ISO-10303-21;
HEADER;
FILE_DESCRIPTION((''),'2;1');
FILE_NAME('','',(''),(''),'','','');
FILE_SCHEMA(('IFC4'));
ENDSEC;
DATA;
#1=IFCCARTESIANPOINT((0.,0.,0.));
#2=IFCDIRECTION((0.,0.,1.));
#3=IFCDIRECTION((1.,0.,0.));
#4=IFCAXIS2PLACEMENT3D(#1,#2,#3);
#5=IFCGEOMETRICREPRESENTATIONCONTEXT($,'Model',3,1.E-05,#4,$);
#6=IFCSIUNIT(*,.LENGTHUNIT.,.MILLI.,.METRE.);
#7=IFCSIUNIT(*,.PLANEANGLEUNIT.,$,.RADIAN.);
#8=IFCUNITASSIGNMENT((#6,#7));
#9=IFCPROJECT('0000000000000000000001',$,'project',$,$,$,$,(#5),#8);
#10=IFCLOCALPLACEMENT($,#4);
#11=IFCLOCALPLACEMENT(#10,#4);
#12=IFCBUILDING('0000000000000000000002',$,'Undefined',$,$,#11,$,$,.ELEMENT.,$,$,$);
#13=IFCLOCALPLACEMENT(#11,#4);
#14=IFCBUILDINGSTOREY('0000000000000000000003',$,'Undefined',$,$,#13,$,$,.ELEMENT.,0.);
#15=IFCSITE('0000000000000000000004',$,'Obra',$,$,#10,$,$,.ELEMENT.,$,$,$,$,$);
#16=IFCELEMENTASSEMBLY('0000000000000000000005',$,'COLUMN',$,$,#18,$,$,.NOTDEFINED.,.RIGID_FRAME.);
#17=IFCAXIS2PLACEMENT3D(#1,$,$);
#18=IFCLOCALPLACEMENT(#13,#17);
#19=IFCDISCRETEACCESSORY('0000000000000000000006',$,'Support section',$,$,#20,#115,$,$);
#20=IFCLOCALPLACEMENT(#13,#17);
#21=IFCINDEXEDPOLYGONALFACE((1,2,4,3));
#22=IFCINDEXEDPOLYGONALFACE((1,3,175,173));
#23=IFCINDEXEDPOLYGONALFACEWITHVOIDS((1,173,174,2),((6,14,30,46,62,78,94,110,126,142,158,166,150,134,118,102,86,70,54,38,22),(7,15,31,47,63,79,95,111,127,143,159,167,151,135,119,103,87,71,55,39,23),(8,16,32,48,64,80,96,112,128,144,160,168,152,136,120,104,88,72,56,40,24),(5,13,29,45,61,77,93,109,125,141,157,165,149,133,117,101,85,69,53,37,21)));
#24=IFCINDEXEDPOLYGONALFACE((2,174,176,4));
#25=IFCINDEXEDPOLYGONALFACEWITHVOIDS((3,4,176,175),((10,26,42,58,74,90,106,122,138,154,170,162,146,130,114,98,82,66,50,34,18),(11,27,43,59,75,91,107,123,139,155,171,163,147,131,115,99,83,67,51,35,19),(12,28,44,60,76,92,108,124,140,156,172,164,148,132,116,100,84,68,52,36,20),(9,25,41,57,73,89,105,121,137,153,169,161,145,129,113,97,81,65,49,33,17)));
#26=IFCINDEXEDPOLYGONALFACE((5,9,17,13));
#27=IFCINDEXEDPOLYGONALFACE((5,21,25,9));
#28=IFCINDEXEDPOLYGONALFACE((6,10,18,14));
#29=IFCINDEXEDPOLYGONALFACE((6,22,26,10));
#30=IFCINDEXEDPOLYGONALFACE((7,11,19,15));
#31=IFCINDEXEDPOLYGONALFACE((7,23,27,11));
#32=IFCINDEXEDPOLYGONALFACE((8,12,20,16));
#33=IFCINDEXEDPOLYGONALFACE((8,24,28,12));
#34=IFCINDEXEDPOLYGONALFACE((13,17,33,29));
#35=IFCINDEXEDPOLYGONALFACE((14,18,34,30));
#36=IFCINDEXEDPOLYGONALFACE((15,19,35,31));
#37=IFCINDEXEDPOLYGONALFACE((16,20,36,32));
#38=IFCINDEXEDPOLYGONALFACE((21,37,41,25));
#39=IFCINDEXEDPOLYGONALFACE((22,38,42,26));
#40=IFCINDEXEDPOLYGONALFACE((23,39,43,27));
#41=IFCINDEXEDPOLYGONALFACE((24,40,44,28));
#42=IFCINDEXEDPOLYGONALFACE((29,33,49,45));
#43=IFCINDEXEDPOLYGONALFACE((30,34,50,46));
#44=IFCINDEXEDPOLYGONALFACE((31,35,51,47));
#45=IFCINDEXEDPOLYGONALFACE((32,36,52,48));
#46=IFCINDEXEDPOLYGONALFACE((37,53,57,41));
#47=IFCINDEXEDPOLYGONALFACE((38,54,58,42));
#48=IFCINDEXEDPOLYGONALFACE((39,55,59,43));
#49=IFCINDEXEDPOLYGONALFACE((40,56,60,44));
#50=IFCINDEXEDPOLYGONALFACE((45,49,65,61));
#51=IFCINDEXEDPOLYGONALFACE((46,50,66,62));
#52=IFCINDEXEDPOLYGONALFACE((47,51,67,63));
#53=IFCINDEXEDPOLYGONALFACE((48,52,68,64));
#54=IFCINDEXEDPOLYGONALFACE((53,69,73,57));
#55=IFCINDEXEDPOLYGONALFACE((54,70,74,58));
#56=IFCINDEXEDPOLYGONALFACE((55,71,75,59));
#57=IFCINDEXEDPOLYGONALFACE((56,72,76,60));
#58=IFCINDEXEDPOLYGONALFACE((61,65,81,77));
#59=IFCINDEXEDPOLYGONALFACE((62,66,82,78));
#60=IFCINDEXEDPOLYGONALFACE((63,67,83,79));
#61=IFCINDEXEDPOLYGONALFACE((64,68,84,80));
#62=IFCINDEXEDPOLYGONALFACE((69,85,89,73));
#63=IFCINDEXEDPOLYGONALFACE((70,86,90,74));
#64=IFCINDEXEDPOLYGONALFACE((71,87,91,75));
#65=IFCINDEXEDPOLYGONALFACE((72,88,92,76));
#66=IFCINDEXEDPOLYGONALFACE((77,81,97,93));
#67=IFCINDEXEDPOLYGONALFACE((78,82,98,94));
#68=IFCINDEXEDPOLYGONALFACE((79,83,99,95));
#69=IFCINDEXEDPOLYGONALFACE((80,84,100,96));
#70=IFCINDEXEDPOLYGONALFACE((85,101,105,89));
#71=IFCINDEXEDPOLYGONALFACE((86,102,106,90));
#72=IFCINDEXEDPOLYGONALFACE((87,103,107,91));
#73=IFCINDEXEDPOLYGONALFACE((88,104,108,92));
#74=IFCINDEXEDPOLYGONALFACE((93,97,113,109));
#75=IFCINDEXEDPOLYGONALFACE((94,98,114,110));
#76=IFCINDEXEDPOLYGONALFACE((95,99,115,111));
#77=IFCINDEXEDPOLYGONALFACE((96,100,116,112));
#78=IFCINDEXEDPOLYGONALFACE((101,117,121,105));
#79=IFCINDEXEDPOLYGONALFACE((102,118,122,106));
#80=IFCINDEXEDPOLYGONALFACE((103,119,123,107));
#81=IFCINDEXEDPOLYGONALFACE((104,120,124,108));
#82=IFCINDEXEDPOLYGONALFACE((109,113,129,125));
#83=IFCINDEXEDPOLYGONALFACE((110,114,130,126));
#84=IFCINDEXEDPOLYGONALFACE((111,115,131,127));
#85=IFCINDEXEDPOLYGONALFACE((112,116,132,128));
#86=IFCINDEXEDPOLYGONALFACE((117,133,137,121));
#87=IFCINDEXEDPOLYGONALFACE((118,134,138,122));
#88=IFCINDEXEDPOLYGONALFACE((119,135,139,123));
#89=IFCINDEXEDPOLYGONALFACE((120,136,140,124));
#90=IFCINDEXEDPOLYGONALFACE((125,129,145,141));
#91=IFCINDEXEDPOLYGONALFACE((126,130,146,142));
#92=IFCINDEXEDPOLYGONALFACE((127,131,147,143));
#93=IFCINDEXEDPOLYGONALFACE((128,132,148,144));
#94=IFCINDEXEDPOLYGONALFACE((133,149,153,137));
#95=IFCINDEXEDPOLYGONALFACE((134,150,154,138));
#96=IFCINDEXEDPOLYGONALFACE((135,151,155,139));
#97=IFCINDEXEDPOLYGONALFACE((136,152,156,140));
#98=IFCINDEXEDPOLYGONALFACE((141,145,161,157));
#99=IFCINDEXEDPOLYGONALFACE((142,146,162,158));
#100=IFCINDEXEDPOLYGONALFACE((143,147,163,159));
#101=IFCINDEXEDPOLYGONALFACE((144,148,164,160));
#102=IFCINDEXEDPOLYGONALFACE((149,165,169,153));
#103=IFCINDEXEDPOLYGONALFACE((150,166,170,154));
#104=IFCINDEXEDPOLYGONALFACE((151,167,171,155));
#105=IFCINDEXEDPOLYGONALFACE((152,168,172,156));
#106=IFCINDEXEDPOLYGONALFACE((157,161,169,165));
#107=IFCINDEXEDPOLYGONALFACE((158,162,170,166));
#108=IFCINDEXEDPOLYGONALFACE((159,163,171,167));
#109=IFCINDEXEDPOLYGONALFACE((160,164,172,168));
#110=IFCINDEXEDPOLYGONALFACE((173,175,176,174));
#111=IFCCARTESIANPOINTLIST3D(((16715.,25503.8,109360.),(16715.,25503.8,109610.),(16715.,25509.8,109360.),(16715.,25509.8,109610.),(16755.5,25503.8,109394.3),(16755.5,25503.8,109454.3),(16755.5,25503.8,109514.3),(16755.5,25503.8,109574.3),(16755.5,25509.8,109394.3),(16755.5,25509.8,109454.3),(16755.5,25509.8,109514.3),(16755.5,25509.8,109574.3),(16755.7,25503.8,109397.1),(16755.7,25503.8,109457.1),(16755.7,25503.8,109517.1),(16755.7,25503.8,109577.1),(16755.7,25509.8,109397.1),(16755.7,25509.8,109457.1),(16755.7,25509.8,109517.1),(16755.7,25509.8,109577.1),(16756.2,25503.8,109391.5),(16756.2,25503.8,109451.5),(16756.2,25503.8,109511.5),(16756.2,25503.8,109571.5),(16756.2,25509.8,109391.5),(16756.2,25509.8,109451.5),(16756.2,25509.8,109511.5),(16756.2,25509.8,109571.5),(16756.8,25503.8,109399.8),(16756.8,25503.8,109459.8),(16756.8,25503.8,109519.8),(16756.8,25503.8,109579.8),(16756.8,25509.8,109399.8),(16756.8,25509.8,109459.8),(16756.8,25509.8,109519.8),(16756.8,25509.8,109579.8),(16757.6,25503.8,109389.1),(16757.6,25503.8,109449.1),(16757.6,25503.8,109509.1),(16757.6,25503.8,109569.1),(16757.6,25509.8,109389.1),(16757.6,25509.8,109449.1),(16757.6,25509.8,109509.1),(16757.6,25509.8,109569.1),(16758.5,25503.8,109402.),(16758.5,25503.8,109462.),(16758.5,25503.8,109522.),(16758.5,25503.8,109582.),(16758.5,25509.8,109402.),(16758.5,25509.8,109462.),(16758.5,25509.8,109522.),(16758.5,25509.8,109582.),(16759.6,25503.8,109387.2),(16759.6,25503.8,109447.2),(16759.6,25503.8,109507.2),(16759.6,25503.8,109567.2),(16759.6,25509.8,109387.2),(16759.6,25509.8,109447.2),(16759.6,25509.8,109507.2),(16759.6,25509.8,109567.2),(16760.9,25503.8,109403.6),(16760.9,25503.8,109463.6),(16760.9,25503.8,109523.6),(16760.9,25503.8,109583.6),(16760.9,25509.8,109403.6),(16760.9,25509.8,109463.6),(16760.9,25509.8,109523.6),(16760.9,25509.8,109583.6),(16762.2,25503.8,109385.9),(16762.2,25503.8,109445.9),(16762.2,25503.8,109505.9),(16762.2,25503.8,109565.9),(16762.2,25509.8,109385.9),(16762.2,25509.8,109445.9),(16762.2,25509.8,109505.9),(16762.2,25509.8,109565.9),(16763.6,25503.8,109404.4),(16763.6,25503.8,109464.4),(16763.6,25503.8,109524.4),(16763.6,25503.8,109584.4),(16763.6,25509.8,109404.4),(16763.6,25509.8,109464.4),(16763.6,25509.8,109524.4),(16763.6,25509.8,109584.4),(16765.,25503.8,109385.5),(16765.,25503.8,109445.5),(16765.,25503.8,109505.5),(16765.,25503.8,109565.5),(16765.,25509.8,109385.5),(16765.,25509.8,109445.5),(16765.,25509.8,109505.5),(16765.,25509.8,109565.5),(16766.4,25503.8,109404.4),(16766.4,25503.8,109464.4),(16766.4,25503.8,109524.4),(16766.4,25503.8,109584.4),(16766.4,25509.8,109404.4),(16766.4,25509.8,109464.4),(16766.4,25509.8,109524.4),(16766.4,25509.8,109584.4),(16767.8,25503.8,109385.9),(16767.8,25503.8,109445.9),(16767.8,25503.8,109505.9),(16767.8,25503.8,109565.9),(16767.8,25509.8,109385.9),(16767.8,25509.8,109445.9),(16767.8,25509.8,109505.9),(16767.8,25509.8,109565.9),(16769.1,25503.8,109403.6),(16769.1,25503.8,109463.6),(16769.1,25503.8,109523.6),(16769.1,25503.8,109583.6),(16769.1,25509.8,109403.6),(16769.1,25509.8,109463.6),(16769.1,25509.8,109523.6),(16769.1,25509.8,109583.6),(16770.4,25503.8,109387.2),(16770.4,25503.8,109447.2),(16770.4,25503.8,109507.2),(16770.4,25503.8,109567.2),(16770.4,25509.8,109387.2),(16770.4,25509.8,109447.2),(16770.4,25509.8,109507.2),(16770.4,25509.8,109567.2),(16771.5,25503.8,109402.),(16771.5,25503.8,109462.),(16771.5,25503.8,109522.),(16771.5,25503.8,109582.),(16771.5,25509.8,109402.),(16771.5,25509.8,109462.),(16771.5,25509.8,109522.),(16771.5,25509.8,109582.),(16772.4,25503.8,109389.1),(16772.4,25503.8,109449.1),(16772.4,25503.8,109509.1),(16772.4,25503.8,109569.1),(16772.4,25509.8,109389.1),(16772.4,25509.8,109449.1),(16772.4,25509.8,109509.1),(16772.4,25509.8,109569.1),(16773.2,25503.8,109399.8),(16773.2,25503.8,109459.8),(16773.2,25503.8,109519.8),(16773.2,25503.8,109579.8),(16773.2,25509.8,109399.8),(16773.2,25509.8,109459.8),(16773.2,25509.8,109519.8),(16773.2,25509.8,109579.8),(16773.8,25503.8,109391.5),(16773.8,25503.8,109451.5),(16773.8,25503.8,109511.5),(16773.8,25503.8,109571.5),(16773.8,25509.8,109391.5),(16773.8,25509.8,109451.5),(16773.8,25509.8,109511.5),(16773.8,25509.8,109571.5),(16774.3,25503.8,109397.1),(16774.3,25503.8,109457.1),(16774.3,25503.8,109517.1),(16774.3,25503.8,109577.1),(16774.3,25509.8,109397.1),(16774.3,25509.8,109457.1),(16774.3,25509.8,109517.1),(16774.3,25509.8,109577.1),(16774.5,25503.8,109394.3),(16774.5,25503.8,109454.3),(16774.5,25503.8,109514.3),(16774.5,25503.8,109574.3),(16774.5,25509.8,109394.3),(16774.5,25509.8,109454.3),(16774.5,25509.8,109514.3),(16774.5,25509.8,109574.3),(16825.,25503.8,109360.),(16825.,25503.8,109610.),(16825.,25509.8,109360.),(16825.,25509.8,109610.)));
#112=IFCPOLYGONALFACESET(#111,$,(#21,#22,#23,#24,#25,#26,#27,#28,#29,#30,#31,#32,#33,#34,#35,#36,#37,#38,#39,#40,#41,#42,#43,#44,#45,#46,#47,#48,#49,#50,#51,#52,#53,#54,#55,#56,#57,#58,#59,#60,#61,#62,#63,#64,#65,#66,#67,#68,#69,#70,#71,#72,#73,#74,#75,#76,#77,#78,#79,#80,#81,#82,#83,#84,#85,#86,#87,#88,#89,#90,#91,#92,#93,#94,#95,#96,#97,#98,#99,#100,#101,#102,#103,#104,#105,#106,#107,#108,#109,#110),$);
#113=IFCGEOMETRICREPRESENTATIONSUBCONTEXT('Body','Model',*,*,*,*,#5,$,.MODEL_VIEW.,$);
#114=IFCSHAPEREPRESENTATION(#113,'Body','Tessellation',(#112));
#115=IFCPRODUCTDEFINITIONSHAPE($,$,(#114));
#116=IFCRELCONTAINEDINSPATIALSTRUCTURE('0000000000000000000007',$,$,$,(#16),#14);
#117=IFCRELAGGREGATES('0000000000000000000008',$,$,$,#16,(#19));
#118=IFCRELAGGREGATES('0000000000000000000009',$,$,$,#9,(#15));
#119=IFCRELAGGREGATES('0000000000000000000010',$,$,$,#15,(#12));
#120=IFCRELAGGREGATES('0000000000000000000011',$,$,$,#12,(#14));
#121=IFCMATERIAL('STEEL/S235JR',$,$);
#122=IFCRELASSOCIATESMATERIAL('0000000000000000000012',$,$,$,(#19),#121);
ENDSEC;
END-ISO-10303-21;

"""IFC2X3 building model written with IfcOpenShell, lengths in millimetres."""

from ifc_helpers import new_model, si_unit, frame, origin_with_axes, origin_2d_with_axis, place, context, subcontext, project, spatial, rectangle, circle, extrude, source, transform, mapped, material, element, aggregate, save


model = new_model("IFC2X3")

# Units and contexts
model_context = context("Model", 3, precision=1e-05, world=origin_with_axes())
body_context = subcontext(model_context, "Body", "Model", "MODEL_VIEW")
ifc_project = project(units=[si_unit("LENGTHUNIT", "METRE", prefix="MILLI"), si_unit("PLANEANGLEUNIT", "RADIAN")], contexts=[model_context])

# Site, building, storey
site_placement = place(None, origin_with_axes())
site = spatial("IfcSite", under=ifc_project, at=site_placement, Name="Obra", CompositionType="ELEMENT")
building_placement = place(site_placement, origin_with_axes())
building = spatial("IfcBuilding", under=site, at=building_placement, Name="Undefined", CompositionType="ELEMENT")
storey_placement = place(building_placement, origin_with_axes())
storey = spatial("IfcBuildingStorey", under=building, at=storey_placement, Name="Undefined", CompositionType="ELEMENT", Elevation=0.0)

# Element assembly, discrete accessory, opening
ifc_material_1 = material(Name="STEEL/S235JR")
shared_shape_1 = source(origin_with_axes(), body_context, "Body", "SweptSolid", [
    extrude(circle(Radius=9.5, at=origin_2d_with_axis()), frame((0.0, -9.8, 0.0), z_axis=(0.0, 1.0, 0.0), x_axis=(1.0, 0.0, 0.0)), (0.0, 0.0, 1.0), 6.2),
])
assembly_1_placement = place(storey_placement, origin_with_axes())
assembly_1 = element("IfcElementAssembly", 1, at=assembly_1_placement, inside=storey, Name="COLUMN", AssemblyPlace="NOTDEFINED", PredefinedType="RIGID_FRAME")
discrete_accessory_1_placement = place(assembly_1_placement, frame((16770.0, 25506.8, 109360.0), z_axis=(0.0, 0.0, 1.0), x_axis=(1.0, 0.0, 0.0)))
discrete_accessory_1 = element("IfcDiscreteAccessory", 2, at=discrete_accessory_1_placement, material=ifc_material_1, Name="Support section", context=body_context, shape_type="SweptSolid", body=[
    extrude(rectangle(XDim=6.0, YDim=110.0, at=origin_2d_with_axis()), frame((0.0, 0.0, 250.0), z_axis=(0.0, 0.0, -1.0), x_axis=(0.0, 1.0, 0.0)), (0.0, 0.0, 1.0), 250.0),
])
opening_1_placement = place(assembly_1_placement, frame((16815.0, 25500.0, 109650.0), z_axis=(-1.0, 0.0, 0.0), x_axis=(0.0, 0.0, -1.0)))
element("IfcOpeningElement", 3, at=opening_1_placement, cuts=discrete_accessory_1, ObjectType="Opening", context=body_context, shape_type="MappedRepresentation", body=[
    mapped(shared_shape_1, transform((75.0, 0.0, 50.0))),
    mapped(shared_shape_1, transform((135.0, 0.0, 50.0))),
    mapped(shared_shape_1, transform((195.0, 0.0, 50.0))),
    mapped(shared_shape_1, transform((255.0, 0.0, 50.0))),
])
aggregate(assembly_1, [discrete_accessory_1])

save(model, "model.ifc")
